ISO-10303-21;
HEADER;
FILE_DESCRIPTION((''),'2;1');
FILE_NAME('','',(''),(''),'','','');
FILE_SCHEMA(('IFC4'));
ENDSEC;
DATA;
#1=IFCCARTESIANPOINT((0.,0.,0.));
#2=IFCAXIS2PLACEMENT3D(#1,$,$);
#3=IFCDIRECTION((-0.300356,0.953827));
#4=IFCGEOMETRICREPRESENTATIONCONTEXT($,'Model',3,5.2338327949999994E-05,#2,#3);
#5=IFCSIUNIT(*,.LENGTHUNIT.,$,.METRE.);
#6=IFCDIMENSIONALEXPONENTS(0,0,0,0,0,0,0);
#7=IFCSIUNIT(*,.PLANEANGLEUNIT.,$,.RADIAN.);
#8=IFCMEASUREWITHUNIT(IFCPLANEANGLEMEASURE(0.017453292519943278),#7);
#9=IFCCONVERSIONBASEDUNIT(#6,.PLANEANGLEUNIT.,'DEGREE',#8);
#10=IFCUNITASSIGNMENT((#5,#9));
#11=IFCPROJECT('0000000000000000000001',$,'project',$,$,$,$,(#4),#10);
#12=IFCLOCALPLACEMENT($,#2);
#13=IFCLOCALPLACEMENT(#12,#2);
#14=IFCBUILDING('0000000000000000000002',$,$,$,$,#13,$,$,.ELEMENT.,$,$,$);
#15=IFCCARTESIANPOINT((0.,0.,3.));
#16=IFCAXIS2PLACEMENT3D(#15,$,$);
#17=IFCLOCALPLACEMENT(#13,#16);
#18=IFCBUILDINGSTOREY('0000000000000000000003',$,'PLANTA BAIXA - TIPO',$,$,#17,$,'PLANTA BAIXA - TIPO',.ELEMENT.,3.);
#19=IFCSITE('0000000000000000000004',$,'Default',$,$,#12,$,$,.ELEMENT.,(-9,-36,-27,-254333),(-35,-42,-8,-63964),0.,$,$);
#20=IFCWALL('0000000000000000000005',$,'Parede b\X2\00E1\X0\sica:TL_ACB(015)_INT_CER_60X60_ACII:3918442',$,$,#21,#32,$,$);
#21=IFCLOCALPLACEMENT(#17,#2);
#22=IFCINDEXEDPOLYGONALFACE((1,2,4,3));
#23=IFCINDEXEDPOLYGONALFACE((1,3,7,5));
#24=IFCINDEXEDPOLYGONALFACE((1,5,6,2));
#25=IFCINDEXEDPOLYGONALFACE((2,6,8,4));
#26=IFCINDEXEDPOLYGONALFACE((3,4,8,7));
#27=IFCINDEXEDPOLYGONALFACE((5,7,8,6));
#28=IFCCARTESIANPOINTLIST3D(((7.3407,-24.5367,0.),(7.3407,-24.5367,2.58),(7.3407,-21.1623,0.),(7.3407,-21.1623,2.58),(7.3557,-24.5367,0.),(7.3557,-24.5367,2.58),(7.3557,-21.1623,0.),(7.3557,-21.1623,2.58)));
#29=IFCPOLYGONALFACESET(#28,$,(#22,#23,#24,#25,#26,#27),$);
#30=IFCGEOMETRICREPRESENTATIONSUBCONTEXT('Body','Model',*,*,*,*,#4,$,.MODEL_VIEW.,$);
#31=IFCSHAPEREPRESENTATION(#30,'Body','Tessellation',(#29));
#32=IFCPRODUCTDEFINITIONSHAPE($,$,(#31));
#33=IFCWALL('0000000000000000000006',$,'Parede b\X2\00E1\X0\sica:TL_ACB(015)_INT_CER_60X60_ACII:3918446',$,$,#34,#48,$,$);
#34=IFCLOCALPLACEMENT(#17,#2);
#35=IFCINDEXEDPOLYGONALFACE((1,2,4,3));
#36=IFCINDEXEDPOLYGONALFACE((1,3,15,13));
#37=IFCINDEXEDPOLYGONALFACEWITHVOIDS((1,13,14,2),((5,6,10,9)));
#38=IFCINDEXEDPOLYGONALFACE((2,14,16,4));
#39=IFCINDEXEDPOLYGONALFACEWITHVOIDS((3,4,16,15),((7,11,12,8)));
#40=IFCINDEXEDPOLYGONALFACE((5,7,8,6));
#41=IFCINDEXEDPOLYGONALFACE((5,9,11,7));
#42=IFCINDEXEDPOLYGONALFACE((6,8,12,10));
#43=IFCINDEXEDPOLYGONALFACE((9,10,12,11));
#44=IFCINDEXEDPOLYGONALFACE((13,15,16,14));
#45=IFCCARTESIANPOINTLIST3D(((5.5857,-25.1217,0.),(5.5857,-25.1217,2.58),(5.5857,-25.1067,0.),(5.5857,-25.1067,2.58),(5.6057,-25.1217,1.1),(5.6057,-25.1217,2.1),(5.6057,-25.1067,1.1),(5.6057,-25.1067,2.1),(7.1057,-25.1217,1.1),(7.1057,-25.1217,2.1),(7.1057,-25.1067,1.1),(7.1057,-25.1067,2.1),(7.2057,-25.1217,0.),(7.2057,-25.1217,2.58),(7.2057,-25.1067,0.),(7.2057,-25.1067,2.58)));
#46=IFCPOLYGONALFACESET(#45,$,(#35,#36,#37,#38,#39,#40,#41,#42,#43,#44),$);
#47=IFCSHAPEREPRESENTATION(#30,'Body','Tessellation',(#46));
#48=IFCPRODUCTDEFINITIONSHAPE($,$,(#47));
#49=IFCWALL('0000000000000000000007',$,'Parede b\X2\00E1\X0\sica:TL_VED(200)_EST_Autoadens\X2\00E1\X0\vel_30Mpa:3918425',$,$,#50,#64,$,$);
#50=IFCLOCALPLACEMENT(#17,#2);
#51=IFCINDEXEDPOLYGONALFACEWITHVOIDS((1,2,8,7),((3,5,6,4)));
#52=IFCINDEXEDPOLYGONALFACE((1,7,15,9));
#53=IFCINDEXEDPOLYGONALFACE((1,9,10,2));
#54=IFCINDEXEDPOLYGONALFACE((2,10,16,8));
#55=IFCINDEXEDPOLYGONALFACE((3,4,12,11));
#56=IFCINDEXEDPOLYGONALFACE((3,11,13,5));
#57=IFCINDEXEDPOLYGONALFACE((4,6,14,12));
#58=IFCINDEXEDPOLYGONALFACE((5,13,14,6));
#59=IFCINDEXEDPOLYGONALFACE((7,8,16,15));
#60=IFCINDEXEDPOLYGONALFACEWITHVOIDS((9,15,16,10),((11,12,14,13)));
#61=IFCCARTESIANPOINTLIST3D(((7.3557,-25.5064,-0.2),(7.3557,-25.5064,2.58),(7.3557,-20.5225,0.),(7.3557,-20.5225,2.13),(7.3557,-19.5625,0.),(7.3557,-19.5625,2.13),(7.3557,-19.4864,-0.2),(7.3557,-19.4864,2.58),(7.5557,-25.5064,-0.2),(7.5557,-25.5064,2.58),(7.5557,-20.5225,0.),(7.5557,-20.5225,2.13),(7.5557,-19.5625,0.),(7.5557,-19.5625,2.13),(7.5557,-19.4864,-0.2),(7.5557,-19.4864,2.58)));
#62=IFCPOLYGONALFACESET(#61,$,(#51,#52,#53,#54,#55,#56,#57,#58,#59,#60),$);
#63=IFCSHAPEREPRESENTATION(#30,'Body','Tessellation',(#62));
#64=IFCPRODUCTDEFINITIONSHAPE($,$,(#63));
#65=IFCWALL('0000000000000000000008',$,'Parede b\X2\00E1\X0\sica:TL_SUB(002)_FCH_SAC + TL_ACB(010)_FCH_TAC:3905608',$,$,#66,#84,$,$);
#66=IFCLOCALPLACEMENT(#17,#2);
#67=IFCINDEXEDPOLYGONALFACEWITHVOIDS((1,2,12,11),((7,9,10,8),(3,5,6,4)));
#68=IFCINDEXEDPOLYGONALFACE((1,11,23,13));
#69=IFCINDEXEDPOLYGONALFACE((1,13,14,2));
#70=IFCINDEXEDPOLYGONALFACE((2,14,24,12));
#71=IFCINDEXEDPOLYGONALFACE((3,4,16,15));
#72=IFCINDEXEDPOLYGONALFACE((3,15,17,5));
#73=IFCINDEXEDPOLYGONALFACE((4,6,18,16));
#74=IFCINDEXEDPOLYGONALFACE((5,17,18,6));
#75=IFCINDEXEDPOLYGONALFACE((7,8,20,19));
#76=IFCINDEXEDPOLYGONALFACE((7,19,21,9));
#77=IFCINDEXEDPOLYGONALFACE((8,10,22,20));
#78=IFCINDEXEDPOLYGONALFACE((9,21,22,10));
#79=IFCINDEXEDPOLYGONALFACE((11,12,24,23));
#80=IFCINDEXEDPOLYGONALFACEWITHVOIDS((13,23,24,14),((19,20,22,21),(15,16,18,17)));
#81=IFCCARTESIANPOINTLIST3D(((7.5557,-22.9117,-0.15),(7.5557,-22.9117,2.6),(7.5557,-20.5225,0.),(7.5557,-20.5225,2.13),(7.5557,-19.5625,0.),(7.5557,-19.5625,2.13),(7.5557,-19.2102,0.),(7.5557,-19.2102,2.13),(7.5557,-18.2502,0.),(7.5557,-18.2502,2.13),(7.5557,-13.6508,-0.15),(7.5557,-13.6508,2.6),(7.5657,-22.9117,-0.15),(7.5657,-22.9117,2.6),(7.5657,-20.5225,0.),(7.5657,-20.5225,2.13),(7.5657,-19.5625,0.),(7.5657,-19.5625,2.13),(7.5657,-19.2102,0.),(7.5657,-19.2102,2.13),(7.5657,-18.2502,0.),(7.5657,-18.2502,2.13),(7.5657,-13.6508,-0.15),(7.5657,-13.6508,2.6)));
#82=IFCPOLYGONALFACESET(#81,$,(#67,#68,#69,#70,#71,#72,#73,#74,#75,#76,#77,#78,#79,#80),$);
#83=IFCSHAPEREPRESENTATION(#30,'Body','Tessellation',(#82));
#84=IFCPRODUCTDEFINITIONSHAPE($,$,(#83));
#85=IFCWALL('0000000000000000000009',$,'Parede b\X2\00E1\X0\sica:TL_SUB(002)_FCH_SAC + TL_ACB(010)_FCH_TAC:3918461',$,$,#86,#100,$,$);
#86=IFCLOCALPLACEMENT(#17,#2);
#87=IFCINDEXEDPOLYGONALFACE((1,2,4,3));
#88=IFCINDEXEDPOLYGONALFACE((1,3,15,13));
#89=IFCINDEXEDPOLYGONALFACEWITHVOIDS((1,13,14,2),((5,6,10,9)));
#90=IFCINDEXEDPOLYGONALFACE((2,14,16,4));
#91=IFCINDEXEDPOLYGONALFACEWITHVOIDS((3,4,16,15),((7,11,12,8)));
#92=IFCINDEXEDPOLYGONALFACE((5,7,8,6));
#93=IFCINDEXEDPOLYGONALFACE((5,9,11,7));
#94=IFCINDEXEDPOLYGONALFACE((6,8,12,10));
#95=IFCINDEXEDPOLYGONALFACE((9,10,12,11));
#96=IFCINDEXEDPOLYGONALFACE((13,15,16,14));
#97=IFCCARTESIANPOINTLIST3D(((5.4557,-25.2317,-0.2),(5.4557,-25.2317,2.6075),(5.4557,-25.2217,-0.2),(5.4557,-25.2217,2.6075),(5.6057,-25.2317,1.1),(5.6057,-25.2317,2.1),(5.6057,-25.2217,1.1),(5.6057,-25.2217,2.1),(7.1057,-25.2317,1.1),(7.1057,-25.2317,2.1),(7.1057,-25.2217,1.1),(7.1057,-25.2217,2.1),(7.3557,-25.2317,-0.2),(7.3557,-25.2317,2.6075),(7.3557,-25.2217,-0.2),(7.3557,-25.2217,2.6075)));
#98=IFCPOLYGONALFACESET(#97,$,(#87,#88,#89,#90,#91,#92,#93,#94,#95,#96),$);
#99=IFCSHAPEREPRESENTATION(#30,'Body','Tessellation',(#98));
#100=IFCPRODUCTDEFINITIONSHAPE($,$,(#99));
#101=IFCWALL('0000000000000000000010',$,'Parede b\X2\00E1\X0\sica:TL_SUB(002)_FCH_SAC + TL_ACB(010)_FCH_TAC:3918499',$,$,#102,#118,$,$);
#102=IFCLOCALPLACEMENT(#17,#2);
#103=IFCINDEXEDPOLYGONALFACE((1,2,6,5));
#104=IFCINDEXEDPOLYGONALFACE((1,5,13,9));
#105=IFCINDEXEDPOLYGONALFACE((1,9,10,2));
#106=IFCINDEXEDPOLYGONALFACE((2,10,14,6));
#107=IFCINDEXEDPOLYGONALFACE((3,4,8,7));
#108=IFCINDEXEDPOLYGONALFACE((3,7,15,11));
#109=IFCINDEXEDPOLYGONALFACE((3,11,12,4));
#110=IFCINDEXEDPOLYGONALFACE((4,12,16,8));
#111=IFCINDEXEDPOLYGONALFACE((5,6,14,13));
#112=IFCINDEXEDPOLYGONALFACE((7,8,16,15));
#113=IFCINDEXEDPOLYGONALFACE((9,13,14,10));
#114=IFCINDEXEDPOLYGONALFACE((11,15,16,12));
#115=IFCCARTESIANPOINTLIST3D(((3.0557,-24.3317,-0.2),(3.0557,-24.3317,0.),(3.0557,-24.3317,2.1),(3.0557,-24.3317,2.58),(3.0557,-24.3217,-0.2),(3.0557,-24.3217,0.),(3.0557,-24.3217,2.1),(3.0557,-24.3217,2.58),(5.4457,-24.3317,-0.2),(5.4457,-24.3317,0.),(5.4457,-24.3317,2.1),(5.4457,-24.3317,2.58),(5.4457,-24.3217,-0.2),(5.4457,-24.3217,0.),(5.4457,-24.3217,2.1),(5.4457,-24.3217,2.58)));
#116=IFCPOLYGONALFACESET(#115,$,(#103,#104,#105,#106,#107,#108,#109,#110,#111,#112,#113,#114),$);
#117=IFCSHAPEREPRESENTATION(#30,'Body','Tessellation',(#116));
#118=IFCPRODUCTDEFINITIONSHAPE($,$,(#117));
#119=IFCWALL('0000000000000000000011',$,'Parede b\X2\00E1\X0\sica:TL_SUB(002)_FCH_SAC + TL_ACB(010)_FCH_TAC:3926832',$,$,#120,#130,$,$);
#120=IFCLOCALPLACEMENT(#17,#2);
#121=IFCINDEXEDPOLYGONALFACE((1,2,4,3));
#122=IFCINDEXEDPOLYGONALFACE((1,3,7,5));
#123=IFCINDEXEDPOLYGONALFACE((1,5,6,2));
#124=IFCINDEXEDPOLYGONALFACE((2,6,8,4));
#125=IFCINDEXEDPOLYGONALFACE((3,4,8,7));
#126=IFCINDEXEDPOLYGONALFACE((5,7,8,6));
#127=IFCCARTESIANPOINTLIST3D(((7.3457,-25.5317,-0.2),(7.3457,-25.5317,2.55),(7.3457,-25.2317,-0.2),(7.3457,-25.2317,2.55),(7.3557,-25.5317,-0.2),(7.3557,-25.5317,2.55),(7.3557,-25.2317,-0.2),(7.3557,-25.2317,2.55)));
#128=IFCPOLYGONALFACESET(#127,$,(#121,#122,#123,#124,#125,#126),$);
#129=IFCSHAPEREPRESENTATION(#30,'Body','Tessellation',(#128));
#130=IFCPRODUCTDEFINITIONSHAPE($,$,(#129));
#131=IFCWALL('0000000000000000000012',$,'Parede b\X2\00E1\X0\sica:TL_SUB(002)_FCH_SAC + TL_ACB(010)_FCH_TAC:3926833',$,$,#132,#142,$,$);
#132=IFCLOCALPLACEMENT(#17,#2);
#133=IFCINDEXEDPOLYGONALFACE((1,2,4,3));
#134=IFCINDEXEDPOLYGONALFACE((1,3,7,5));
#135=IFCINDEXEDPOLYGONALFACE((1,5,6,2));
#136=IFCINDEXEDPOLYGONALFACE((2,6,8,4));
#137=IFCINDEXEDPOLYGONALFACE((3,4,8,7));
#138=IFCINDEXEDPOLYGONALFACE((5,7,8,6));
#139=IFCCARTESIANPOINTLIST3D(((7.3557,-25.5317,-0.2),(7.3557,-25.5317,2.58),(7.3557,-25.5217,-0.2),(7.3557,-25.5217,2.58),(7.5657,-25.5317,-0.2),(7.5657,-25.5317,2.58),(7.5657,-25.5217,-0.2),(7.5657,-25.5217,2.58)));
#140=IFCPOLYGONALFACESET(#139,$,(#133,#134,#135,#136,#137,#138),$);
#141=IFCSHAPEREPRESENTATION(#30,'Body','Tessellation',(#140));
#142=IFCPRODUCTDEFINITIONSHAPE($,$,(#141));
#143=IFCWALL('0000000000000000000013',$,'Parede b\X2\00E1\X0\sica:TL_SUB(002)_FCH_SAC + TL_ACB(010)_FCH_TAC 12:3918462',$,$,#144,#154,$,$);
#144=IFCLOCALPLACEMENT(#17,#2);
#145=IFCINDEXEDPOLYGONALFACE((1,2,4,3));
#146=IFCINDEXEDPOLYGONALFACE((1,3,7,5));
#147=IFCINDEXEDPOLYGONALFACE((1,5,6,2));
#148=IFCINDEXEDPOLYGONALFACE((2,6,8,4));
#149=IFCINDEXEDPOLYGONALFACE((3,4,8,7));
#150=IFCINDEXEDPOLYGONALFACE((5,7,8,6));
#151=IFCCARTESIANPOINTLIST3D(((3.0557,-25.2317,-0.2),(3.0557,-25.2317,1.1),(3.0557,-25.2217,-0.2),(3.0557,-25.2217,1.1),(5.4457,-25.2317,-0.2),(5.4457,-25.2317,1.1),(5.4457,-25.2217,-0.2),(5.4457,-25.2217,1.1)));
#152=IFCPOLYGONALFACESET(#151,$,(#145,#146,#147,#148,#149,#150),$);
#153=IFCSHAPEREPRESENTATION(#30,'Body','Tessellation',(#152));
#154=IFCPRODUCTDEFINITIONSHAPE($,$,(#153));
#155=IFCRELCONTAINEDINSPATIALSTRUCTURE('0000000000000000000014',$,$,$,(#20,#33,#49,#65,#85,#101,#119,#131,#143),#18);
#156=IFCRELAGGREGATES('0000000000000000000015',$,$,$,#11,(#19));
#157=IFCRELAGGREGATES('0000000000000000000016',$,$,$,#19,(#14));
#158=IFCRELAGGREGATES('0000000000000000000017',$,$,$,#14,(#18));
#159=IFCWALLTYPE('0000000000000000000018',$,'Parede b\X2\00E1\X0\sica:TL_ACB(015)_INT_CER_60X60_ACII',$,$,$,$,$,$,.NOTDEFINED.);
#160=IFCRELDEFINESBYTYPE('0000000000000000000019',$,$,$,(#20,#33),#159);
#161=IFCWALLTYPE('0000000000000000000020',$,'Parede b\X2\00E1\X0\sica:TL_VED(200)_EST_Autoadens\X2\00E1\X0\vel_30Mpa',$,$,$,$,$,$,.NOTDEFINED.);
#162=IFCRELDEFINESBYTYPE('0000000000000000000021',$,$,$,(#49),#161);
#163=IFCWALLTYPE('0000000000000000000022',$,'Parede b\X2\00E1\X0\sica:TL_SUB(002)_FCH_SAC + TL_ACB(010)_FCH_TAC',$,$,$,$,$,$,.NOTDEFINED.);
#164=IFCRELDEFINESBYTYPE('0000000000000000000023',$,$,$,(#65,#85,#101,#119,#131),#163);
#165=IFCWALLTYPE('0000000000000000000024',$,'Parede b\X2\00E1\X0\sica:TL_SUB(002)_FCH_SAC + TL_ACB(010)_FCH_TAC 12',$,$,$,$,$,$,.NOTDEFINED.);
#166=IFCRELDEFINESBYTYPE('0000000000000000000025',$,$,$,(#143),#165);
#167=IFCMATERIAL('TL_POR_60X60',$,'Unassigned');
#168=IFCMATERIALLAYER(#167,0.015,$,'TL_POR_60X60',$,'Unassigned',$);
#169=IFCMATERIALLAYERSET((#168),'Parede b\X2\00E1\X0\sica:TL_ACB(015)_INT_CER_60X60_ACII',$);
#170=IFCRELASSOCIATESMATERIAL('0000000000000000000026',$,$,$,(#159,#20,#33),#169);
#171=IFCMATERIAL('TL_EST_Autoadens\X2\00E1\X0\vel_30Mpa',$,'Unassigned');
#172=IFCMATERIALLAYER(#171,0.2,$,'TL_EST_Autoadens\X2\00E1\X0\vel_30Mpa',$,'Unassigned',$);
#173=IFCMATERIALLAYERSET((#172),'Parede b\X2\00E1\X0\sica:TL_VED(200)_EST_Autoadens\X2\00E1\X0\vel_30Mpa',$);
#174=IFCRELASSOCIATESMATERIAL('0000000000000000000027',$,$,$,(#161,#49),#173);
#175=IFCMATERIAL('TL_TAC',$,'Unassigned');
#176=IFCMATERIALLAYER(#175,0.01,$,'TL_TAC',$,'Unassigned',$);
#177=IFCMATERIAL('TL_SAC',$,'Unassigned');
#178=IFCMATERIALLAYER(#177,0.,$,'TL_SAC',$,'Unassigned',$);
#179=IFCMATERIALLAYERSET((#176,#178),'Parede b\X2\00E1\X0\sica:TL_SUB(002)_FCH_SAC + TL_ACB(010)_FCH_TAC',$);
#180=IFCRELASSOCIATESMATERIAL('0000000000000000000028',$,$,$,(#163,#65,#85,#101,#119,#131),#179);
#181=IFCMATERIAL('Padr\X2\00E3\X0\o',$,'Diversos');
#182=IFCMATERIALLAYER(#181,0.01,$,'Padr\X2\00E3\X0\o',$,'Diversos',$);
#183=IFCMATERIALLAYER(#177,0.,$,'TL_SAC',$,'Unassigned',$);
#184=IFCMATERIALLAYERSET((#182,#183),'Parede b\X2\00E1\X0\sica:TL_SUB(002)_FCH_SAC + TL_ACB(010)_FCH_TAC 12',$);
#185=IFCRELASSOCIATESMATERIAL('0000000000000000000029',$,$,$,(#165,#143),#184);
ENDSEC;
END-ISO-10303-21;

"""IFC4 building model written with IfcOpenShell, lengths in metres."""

from ifc_helpers import new_model, entity, si_unit, converted_unit, direction, frame, frame_2d, origin, place, context, subcontext, project, spatial, rectangle, extrude, material, layer, layer_set, layer_usage, type_object, element, save


model = new_model("IFC4")

# Units and contexts
model_context = context("Model", 3, precision=5.2338327949999994e-05, world=origin(), true_north=direction((-0.300356, 0.953827)))
body_context = subcontext(model_context, "Body", "Model", "MODEL_VIEW")
ifc_project = project(units=[si_unit("LENGTHUNIT", "METRE"), converted_unit("PLANEANGLEUNIT", "DEGREE", entity("IfcPlaneAngleMeasure", 0.017453292519943278), si_unit("PLANEANGLEUNIT", "RADIAN"), dimensions=[0, 0, 0, 0, 0, 0, 0])], contexts=[model_context])

# Site, building, storey
site_placement = place(None, origin())
site = spatial("IfcSite", under=ifc_project, at=site_placement, Name="Default", CompositionType="ELEMENT", RefLatitude=(-9, -36, -27, -254333), RefLongitude=(-35, -42, -8, -63964), RefElevation=0.0)
building_placement = place(site_placement, origin())
building = spatial("IfcBuilding", under=site, at=building_placement, CompositionType="ELEMENT")
storey_placement = place(building_placement, frame((0.0, 0.0, 3.0)))
storey = spatial("IfcBuildingStorey", under=building, at=storey_placement, Name="PLANTA BAIXA - TIPO", LongName="PLANTA BAIXA - TIPO", CompositionType="ELEMENT", Elevation=3.0)

# Shared definitions
ifc_material_1 = material(Name="TL_EST_Autoadensável_30Mpa", Category="Unassigned")

# Shared definitions
ifc_material_2 = material(Name="TL_SAC", Category="Unassigned")

# Wall
ifc_material_3 = material(Name="TL_POR_60X60", Category="Unassigned")
ifc_layer_1 = layer(ifc_material_3, 0.015, Name="TL_POR_60X60", Category="Unassigned")
ifc_layer_set_1 = layer_set([ifc_layer_1], Name="Parede básica:TL_ACB(015)_INT_CER_60X60_ACII")
ifc_layer_usage_1 = layer_usage(ifc_layer_set_1, "AXIS2", "POSITIVE", -0.0075)
wall_type_1 = type_object("IfcWallType", Name="Parede básica:TL_ACB(015)_INT_CER_60X60_ACII", PredefinedType="NOTDEFINED", material=ifc_layer_set_1)
wall_1_placement = place(storey_placement, frame((7.3482, -21.1623, 0.0), z_axis=(0.0, 0.0, 1.0), x_axis=(0.0, -1.0, 0.0)))
element("IfcWall", 1, at=wall_1_placement, inside=storey, type_object=wall_type_1, material=ifc_layer_usage_1, Name="Parede básica:TL_ACB(015)_INT_CER_60X60_ACII:3918442", context=body_context, shape_type="SweptSolid", body=[
    extrude(rectangle(XDim=3.3744, YDim=0.015, at=frame_2d((1.6872, 0.0), x_axis=(-1.0, 0.0))), origin(), (0.0, 0.0, 1.0), 2.58),
])

# Walls, openings
ifc_layer_usage_2 = layer_usage(ifc_layer_set_1, "AXIS2", "POSITIVE", -0.0075)
wall_2_placement = place(storey_placement, frame((7.2057, -25.1142, 0.0), z_axis=(0.0, 0.0, 1.0), x_axis=(-1.0, 0.0, 0.0)))
wall_2 = element("IfcWall", 2, at=wall_2_placement, inside=storey, type_object=wall_type_1, material=ifc_layer_usage_2, Name="Parede básica:TL_ACB(015)_INT_CER_60X60_ACII:3918446", context=body_context, shape_type="SweptSolid", body=[
    extrude(rectangle(XDim=1.62, YDim=0.015, at=frame_2d((0.81, 0.0), x_axis=(-1.0, 0.0))), origin(), (0.0, 0.0, 1.0), 2.58),
])
opening_1_placement = place(wall_2_placement, frame((7.2057, -25.1142, 1.1)))
element("IfcOpeningElement", 3, at=opening_1_placement, cuts=wall_2, PredefinedType="OPENING", context=body_context, shape_type="SweptSolid", body=[
    extrude(rectangle(XDim=1.0, YDim=1.5, at=frame_2d((0.0, 0.0), x_axis=(0.0, 1.0))), frame((-6.3557, 23.5977, 0.5), z_axis=(0.0, 1.0, 0.0), x_axis=(1.0, 0.0, 0.0)), (0.0, 0.0, 1.0), 3.048),
])
ifc_layer_2 = layer(ifc_material_1, 0.2, Name="TL_EST_Autoadensável_30Mpa", Category="Unassigned")
ifc_layer_set_2 = layer_set([ifc_layer_2], Name="Parede básica:TL_VED(200)_EST_Autoadensável_30Mpa")
ifc_layer_usage_3 = layer_usage(ifc_layer_set_2, "AXIS2", "POSITIVE", -0.1)
wall_type_2 = type_object("IfcWallType", Name="Parede básica:TL_VED(200)_EST_Autoadensável_30Mpa", PredefinedType="NOTDEFINED", material=ifc_layer_set_2)
wall_3_placement = place(storey_placement, frame((7.4557, -25.5064, -0.2), z_axis=(0.0, 0.0, 1.0), x_axis=(0.0, 1.0, 0.0)))
wall_3 = element("IfcWall", 4, at=wall_3_placement, inside=storey, type_object=wall_type_2, material=ifc_layer_usage_3, Name="Parede básica:TL_VED(200)_EST_Autoadensável_30Mpa:3918425", context=body_context, shape_type="SweptSolid", body=[
    extrude(rectangle(XDim=6.02, YDim=0.2, at=frame_2d((3.01, 0.0), x_axis=(-1.0, 0.0))), origin(), (0.0, 0.0, 1.0), 2.78),
])
opening_2_placement = place(wall_3_placement, frame((4.9838, -0.1, 0.2)))
element("IfcOpeningElement", 5, at=opening_2_placement, cuts=wall_3, PredefinedType="OPENING", context=body_context, shape_type="SweptSolid", body=[
    extrude(rectangle(XDim=2.13, YDim=0.96, at=frame_2d((1.065, 0.48), x_axis=(1.0, 0.0))), frame((0.0, 0.0, 0.0), z_axis=(0.0, 1.0, 0.0), x_axis=(0.0, 0.0, 1.0)), (0.0, 0.0, 1.0), 0.2),
])

# Wall, openings
ifc_material_4 = material(Name="TL_TAC", Category="Unassigned")
ifc_layer_3 = layer(ifc_material_4, 0.01, Name="TL_TAC", Category="Unassigned")
ifc_layer_4 = layer(ifc_material_2, 0.0, Name="TL_SAC", Category="Unassigned")
ifc_layer_set_3 = layer_set([ifc_layer_3, ifc_layer_4], Name="Parede básica:TL_SUB(002)_FCH_SAC + TL_ACB(010)_FCH_TAC")
ifc_layer_usage_4 = layer_usage(ifc_layer_set_3, "AXIS2", "NEGATIVE", 0.005)
wall_type_3 = type_object("IfcWallType", Name="Parede básica:TL_SUB(002)_FCH_SAC + TL_ACB(010)_FCH_TAC", PredefinedType="NOTDEFINED", material=ifc_layer_set_3)
wall_4_placement = place(storey_placement, frame((7.5607, -22.9117, -0.15), z_axis=(0.0, 0.0, 1.0), x_axis=(0.0, 1.0, 0.0)))
wall_4 = element("IfcWall", 6, at=wall_4_placement, inside=storey, type_object=wall_type_3, material=ifc_layer_usage_4, Name="Parede básica:TL_SUB(002)_FCH_SAC + TL_ACB(010)_FCH_TAC:3905608", context=body_context, shape_type="SweptSolid", body=[
    extrude(rectangle(XDim=9.2609, YDim=0.01, at=frame_2d((4.6305, 0.0), x_axis=(-1.0, 0.0))), origin(), (0.0, 0.0, 1.0), 2.75),
])
opening_3_placement = place(wall_4_placement, frame((22.9117, 7.5607, 0.15)))
element("IfcOpeningElement", 7, at=opening_3_placement, cuts=wall_4, PredefinedType="OPENING", context=body_context, shape_type="SweptSolid", body=[
    extrude(rectangle(XDim=2.13, YDim=0.96, at=frame_2d((0.0, 0.0), x_axis=(1.0, 0.0))), frame((-20.0425, -8.8797, 1.065), z_axis=(0.0, 1.0, 0.0), x_axis=(0.0, 0.0, 1.0)), (0.0, 0.0, 1.0), 3.048),
])
opening_4_placement = place(wall_4_placement, frame((22.9117, 7.5607, 0.15)))
element("IfcOpeningElement", 8, at=opening_4_placement, cuts=wall_4, PredefinedType="OPENING", context=body_context, shape_type="SweptSolid", body=[
    extrude(rectangle(XDim=2.13, YDim=0.96, at=frame_2d((0.0, 0.0), x_axis=(0.0, 1.0))), frame((-18.7302, -8.8797, 1.065), z_axis=(0.0, 1.0, 0.0), x_axis=(-1.0, 0.0, 0.0)), (0.0, 0.0, 1.0), 3.048),
])

# Walls, openings
ifc_layer_usage_5 = layer_usage(ifc_layer_set_3, "AXIS2", "POSITIVE", -0.005)
wall_5_placement = place(storey_placement, frame((7.3557, -25.2267, -0.2), z_axis=(0.0, 0.0, 1.0), x_axis=(-1.0, 0.0, 0.0)))
wall_5 = element("IfcWall", 9, at=wall_5_placement, inside=storey, type_object=wall_type_3, material=ifc_layer_usage_5, Name="Parede básica:TL_SUB(002)_FCH_SAC + TL_ACB(010)_FCH_TAC:3918461", context=body_context, shape_type="SweptSolid", body=[
    extrude(rectangle(XDim=1.9, YDim=0.01, at=frame_2d((0.95, 0.0), x_axis=(-1.0, 0.0))), origin(), (0.0, 0.0, 1.0), 2.8075),
])
opening_5_placement = place(wall_5_placement, frame((7.3557, -25.2267, 1.3)))
element("IfcOpeningElement", 10, at=opening_5_placement, cuts=wall_5, PredefinedType="OPENING", context=body_context, shape_type="SweptSolid", body=[
    extrude(rectangle(XDim=1.0, YDim=1.5, at=frame_2d((0.0, 0.0), x_axis=(0.0, 1.0))), frame((-6.3557, 23.5977, 0.5), z_axis=(0.0, 1.0, 0.0), x_axis=(1.0, 0.0, 0.0)), (0.0, 0.0, 1.0), 3.048),
])
ifc_layer_usage_6 = layer_usage(ifc_layer_set_3, "AXIS2", "NEGATIVE", 0.005)
wall_6_placement = place(storey_placement, frame((5.4457, -24.3267, -0.2), z_axis=(0.0, 0.0, 1.0), x_axis=(-1.0, 0.0, 0.0)))
wall_6 = element("IfcWall", 11, at=wall_6_placement, inside=storey, type_object=wall_type_3, material=ifc_layer_usage_6, Name="Parede básica:TL_SUB(002)_FCH_SAC + TL_ACB(010)_FCH_TAC:3918499", context=body_context, shape_type="SweptSolid", body=[
    extrude(rectangle(XDim=2.39, YDim=0.01, at=frame_2d((1.195, 0.0), x_axis=(-1.0, 0.0))), origin(), (0.0, 0.0, 1.0), 2.78),
])
opening_6_placement = place(wall_6_placement, frame((5.4457, -24.3267, 0.2)))
element("IfcOpeningElement", 12, at=opening_6_placement, cuts=wall_6, PredefinedType="OPENING", context=body_context, shape_type="SweptSolid", body=[
    extrude(rectangle(XDim=2.1, YDim=2.4, at=frame_2d((0.0, 0.0), x_axis=(0.0, 1.0))), frame((-4.2557, 22.7977, 1.05), z_axis=(0.0, 1.0, 0.0), x_axis=(-1.0, 0.0, 0.0)), (0.0, 0.0, 1.0), 3.048),
])

# Walls
ifc_layer_usage_7 = layer_usage(ifc_layer_set_3, "AXIS2", "NEGATIVE", 0.005)
wall_7_placement = place(storey_placement, frame((7.3507, -25.2317, -0.2), z_axis=(0.0, 0.0, 1.0), x_axis=(0.0, -1.0, 0.0)))
element("IfcWall", 13, at=wall_7_placement, inside=storey, type_object=wall_type_3, material=ifc_layer_usage_7, Name="Parede básica:TL_SUB(002)_FCH_SAC + TL_ACB(010)_FCH_TAC:3926832", context=body_context, shape_type="SweptSolid", body=[
    extrude(rectangle(XDim=0.3, YDim=0.01, at=frame_2d((0.15, 0.0), x_axis=(-1.0, 0.0))), origin(), (0.0, 0.0, 1.0), 2.75),
])
ifc_layer_usage_8 = layer_usage(ifc_layer_set_3, "AXIS2", "NEGATIVE", 0.005)
wall_8_placement = place(storey_placement, frame((7.3557, -25.5267, -0.2)))
element("IfcWall", 14, at=wall_8_placement, inside=storey, type_object=wall_type_3, material=ifc_layer_usage_8, Name="Parede básica:TL_SUB(002)_FCH_SAC + TL_ACB(010)_FCH_TAC:3926833", context=body_context, shape_type="SweptSolid", body=[
    extrude(rectangle(XDim=0.21, YDim=0.01, at=frame_2d((0.105, 0.0), x_axis=(-1.0, 0.0))), origin(), (0.0, 0.0, 1.0), 2.78),
])
ifc_material_5 = material(Name="Padrão", Category="Diversos")
ifc_layer_5 = layer(ifc_material_5, 0.01, Name="Padrão", Category="Diversos")
ifc_layer_6 = layer(ifc_material_2, 0.0, Name="TL_SAC", Category="Unassigned")
ifc_layer_set_4 = layer_set([ifc_layer_5, ifc_layer_6], Name="Parede básica:TL_SUB(002)_FCH_SAC + TL_ACB(010)_FCH_TAC 12")
ifc_layer_usage_9 = layer_usage(ifc_layer_set_4, "AXIS2", "POSITIVE", -0.005)
wall_type_4 = type_object("IfcWallType", Name="Parede básica:TL_SUB(002)_FCH_SAC + TL_ACB(010)_FCH_TAC 12", PredefinedType="NOTDEFINED", material=ifc_layer_set_4)
wall_9_placement = place(storey_placement, frame((5.4457, -25.2267, -0.2), z_axis=(0.0, 0.0, 1.0), x_axis=(-1.0, 0.0, 0.0)))
element("IfcWall", 15, at=wall_9_placement, inside=storey, type_object=wall_type_4, material=ifc_layer_usage_9, Name="Parede básica:TL_SUB(002)_FCH_SAC + TL_ACB(010)_FCH_TAC 12:3918462", context=body_context, shape_type="SweptSolid", body=[
    extrude(rectangle(XDim=2.39, YDim=0.01, at=frame_2d((1.195, 0.0), x_axis=(-1.0, 0.0))), origin(), (0.0, 0.0, 1.0), 1.3),
])

save(model, "model.ifc")
